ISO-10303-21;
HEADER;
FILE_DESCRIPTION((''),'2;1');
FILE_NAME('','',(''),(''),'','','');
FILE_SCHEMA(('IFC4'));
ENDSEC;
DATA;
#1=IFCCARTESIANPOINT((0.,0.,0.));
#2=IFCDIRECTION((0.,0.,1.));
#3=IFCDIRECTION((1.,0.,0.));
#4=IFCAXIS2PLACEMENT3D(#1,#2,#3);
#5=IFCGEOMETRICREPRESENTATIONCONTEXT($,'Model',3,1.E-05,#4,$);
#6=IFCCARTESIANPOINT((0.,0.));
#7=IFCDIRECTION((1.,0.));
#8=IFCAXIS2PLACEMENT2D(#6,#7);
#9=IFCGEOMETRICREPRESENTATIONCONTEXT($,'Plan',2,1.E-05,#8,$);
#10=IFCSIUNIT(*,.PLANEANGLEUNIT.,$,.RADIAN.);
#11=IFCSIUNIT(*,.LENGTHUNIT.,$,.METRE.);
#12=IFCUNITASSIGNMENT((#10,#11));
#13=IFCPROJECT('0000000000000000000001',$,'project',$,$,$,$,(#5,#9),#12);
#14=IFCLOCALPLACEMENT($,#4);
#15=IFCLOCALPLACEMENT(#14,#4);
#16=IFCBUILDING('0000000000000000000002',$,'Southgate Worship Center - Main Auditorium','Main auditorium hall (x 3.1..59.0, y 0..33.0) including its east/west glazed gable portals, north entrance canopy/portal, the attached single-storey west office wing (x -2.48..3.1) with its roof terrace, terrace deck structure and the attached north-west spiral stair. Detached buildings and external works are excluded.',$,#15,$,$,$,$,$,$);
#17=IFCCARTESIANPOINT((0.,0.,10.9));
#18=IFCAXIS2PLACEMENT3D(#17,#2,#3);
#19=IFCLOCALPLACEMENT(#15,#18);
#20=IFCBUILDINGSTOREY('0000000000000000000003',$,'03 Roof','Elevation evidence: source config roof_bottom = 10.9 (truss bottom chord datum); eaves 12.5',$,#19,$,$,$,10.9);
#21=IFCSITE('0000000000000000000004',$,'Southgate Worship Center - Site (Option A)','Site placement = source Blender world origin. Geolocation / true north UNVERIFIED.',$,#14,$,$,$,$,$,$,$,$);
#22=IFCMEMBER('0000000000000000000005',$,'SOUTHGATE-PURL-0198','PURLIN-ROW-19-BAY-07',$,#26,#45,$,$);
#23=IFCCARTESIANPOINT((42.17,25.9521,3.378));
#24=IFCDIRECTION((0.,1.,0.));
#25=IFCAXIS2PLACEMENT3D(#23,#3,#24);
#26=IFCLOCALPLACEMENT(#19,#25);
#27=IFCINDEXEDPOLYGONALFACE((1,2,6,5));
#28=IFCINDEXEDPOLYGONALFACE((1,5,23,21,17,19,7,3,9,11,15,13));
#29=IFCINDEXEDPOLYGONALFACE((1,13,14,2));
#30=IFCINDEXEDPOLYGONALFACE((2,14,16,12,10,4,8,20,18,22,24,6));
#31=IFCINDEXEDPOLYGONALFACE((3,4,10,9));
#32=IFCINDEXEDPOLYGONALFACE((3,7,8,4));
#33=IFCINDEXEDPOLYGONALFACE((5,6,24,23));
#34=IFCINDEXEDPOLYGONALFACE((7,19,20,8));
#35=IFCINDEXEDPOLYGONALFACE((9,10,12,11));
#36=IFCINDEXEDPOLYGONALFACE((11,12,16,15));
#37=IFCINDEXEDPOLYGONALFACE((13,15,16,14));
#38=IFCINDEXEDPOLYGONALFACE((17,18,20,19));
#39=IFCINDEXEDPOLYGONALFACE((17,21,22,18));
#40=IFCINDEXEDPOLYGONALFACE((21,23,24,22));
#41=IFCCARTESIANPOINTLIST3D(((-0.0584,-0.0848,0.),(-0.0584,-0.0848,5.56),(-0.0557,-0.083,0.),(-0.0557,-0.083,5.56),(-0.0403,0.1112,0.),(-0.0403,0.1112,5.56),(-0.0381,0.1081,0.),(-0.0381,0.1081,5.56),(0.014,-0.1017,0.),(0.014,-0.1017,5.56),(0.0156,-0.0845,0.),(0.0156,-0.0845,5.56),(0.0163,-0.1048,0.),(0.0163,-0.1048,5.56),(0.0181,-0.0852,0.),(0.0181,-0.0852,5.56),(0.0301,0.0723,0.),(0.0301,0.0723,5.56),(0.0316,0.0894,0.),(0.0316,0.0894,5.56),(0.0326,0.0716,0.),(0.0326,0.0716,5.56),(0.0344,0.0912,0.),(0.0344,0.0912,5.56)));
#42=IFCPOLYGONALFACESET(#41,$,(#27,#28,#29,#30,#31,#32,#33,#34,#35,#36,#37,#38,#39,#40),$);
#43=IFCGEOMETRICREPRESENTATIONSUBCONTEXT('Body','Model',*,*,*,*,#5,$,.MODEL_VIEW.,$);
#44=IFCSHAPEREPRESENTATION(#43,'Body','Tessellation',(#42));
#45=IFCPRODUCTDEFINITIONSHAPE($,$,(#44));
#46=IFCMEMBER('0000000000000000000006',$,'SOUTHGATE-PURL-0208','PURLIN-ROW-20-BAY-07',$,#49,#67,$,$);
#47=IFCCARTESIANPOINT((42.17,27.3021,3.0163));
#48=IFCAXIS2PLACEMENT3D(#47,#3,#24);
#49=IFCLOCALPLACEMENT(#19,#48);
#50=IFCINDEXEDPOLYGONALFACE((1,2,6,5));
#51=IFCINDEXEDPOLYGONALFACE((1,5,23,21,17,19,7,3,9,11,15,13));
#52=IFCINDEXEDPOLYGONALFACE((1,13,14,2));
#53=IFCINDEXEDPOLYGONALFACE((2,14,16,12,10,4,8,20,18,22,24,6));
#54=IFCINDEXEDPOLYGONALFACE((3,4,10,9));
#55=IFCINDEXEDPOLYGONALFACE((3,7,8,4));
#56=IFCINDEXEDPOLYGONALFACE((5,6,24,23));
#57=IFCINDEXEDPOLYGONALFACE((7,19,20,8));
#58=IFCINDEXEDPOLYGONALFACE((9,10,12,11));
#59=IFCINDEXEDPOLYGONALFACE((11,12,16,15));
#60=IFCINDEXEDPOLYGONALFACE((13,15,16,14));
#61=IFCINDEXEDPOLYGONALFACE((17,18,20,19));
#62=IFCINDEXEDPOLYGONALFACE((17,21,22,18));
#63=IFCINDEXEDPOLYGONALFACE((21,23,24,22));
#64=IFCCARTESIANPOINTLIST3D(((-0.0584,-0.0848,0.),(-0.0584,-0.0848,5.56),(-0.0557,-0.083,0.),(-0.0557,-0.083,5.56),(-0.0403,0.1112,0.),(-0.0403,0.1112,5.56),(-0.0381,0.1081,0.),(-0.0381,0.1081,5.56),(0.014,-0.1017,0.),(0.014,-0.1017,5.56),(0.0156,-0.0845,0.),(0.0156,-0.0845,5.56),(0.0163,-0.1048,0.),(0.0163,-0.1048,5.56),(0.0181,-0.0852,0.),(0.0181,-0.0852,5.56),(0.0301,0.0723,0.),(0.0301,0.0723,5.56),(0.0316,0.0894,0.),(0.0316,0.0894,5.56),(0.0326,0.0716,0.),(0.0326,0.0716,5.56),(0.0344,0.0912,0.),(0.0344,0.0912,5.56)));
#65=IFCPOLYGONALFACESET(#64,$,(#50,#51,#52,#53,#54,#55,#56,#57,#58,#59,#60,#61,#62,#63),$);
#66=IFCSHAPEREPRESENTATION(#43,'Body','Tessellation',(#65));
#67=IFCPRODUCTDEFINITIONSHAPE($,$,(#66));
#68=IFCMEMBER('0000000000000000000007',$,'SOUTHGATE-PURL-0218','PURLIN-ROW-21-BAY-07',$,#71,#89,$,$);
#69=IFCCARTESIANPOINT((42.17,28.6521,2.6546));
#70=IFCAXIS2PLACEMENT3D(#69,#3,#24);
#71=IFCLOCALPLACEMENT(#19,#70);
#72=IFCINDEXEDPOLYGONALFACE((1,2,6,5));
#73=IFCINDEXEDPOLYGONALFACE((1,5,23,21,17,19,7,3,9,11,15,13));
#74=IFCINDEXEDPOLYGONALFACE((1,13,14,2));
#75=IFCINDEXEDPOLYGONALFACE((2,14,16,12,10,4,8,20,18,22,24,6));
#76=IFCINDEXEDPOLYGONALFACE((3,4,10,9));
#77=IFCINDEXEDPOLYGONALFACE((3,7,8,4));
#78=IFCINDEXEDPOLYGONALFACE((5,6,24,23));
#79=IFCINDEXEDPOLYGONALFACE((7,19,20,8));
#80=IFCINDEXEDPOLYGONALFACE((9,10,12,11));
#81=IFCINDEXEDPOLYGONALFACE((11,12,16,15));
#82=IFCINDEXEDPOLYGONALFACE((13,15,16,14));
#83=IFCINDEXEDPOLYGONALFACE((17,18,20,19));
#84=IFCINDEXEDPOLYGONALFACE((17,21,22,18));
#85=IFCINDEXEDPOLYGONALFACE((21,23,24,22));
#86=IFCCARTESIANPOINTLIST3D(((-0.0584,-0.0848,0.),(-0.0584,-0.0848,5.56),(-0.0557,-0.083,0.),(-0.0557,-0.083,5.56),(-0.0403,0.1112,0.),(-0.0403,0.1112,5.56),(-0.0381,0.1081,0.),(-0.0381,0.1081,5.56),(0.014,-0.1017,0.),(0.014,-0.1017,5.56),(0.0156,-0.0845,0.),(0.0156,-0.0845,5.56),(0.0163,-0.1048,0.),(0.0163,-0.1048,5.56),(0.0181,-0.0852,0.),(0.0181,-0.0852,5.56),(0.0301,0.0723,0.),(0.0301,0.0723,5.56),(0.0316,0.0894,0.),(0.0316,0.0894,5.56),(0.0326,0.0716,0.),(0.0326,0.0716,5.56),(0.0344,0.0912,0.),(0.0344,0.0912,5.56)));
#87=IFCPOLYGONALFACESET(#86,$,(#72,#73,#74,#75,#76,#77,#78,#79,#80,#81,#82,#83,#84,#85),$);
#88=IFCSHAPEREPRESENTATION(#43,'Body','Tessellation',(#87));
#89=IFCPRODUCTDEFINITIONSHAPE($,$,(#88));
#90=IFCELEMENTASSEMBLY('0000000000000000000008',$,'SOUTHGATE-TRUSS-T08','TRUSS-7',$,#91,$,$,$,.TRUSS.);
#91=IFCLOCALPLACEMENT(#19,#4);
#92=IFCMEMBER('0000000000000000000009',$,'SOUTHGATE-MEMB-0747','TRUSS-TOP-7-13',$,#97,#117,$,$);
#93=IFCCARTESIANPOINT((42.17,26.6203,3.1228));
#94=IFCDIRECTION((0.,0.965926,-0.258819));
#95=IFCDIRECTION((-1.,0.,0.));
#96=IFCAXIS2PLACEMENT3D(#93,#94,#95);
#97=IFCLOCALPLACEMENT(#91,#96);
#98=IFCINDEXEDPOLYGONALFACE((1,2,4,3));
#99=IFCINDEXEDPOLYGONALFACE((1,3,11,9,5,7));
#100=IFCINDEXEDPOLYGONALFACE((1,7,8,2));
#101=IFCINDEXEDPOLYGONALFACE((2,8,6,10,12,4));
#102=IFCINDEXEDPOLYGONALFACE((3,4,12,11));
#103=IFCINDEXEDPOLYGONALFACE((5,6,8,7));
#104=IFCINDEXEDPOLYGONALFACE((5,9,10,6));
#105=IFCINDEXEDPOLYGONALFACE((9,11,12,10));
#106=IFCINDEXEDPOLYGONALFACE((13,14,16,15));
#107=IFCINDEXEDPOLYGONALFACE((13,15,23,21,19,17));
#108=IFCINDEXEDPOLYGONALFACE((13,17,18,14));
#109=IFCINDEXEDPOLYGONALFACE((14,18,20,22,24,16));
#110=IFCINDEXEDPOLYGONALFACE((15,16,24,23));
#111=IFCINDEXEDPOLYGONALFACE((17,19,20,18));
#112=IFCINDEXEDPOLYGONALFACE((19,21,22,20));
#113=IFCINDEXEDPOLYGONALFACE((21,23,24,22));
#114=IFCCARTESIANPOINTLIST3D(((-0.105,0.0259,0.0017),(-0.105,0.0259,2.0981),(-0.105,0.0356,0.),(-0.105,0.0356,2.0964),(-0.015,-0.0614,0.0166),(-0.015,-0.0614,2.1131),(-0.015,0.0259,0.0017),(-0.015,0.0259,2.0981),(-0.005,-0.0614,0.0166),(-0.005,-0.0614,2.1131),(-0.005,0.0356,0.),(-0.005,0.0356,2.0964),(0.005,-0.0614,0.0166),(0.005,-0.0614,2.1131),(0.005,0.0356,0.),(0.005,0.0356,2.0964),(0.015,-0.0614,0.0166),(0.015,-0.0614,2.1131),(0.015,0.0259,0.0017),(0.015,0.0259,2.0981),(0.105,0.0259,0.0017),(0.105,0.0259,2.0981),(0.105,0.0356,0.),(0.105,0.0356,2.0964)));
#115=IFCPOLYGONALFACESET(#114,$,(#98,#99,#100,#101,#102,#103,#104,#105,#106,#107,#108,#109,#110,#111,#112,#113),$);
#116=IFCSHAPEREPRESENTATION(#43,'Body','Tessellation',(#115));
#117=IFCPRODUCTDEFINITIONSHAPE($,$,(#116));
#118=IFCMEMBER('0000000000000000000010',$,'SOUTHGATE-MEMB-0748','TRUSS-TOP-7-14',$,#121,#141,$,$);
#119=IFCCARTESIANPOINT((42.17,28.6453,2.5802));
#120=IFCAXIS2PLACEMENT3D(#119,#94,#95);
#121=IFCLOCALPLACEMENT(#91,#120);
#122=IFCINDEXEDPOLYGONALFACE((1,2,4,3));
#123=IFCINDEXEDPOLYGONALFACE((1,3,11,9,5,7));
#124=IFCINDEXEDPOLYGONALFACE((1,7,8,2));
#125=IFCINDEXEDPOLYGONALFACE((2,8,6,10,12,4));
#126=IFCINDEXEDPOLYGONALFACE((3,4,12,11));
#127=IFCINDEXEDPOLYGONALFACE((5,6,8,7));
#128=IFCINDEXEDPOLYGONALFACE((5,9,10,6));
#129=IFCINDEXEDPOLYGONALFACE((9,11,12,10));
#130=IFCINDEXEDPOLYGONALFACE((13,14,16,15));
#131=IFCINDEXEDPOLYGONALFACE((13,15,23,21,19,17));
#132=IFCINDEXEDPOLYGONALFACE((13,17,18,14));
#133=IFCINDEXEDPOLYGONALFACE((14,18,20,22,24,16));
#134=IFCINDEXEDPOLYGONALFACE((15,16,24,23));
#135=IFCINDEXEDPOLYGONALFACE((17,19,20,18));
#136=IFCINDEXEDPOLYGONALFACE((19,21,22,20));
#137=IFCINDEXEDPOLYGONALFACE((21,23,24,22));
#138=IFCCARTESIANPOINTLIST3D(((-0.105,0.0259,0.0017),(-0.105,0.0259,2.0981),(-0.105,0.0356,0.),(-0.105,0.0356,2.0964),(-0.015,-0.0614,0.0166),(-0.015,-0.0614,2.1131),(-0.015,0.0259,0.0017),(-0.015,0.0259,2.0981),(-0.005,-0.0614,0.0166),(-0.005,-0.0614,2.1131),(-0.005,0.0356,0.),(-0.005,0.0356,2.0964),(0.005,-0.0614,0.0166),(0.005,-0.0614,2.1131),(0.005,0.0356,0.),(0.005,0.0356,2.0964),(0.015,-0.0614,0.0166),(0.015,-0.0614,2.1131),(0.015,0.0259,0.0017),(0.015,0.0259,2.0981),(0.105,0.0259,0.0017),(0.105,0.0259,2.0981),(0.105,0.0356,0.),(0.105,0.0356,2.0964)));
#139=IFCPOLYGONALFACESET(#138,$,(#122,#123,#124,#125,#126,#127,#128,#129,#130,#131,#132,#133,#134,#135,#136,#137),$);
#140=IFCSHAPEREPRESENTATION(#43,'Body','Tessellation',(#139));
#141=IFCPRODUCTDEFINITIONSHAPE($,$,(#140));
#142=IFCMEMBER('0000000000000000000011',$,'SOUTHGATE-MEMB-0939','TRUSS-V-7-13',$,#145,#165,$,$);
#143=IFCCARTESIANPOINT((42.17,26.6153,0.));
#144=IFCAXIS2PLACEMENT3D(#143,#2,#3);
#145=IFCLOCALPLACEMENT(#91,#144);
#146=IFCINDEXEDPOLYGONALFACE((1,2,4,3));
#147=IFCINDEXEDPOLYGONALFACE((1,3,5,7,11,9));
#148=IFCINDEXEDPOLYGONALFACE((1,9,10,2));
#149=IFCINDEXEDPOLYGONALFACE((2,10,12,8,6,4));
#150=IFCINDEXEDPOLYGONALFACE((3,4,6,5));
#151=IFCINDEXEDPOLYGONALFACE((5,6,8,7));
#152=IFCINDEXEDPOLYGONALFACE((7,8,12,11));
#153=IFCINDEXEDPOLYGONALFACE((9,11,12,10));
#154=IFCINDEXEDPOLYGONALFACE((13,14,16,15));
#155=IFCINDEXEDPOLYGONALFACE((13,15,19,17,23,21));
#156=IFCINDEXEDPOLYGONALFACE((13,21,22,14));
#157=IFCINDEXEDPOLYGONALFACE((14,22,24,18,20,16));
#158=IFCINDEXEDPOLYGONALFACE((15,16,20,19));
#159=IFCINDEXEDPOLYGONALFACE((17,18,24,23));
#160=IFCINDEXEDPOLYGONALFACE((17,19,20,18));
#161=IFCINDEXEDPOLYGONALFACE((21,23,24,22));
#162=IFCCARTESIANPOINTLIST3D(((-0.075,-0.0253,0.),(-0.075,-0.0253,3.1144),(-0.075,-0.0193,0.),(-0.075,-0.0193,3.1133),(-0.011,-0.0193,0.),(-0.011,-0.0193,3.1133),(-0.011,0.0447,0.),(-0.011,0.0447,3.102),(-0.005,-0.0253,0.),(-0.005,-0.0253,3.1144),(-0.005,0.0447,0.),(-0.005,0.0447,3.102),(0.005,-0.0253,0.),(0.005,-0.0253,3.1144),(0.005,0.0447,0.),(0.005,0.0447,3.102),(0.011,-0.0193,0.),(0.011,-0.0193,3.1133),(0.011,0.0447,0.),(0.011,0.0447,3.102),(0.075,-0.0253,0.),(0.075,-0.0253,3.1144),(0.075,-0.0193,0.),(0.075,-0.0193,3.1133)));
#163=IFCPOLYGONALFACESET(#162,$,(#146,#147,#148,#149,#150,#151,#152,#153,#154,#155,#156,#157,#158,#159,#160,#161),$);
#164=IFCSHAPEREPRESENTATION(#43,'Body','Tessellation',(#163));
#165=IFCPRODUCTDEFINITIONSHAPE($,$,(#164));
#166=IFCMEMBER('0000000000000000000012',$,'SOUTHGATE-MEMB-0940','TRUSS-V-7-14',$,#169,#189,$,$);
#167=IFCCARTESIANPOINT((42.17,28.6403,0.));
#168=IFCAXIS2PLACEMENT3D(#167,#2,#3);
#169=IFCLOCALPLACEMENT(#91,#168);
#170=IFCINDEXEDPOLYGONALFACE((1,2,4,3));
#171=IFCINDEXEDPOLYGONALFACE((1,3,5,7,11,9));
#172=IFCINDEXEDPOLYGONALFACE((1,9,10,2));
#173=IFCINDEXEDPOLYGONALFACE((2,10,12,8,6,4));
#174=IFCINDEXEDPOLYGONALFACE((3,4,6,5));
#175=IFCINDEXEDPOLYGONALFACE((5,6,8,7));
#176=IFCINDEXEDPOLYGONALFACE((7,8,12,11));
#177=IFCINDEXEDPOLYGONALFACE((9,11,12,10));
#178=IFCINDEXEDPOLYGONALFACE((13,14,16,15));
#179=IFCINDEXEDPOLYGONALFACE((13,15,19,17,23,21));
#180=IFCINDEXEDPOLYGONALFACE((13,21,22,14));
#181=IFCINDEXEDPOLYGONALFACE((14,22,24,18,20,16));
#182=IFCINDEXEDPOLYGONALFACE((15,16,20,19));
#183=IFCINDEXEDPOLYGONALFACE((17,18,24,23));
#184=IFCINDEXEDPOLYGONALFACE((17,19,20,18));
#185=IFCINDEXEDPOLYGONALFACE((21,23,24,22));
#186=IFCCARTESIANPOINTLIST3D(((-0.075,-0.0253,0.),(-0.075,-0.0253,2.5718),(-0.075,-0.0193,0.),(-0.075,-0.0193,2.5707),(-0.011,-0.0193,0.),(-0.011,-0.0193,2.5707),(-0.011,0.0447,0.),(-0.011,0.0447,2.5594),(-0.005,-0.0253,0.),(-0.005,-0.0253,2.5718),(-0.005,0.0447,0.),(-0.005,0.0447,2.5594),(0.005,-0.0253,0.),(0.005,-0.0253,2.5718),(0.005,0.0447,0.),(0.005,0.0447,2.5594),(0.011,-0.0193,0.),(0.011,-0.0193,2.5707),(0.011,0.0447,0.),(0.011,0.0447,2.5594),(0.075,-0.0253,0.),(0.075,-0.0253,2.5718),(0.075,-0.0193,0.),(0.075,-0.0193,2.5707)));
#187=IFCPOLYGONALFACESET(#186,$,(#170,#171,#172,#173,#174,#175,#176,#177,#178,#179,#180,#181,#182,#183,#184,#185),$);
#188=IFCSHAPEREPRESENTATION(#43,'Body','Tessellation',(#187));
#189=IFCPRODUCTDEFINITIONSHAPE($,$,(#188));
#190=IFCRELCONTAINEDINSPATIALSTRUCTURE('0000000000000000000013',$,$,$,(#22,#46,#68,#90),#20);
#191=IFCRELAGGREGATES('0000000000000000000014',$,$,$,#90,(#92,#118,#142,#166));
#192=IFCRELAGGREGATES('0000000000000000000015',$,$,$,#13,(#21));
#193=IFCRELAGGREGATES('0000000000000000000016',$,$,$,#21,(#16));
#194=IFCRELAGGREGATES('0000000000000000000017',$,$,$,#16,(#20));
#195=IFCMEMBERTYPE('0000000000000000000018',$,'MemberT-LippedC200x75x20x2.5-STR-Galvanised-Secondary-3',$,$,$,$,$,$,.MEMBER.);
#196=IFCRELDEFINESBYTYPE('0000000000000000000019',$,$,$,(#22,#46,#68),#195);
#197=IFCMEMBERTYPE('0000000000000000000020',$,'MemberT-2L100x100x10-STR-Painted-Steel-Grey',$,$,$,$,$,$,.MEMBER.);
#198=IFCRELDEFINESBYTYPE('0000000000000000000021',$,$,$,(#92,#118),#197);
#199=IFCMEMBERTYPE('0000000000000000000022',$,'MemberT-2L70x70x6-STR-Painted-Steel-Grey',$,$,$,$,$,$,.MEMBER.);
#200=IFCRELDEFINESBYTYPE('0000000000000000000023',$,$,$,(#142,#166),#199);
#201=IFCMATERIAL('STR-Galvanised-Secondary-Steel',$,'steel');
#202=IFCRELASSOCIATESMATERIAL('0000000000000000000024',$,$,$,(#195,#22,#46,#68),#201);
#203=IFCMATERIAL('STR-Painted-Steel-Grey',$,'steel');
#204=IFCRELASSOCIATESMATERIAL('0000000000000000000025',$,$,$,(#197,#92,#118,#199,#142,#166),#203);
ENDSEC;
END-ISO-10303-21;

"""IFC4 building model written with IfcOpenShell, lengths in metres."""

from ifc_helpers import new_model, si_unit, frame, origin_with_axes, origin_2d_with_axis, place, context, subcontext, project, spatial, indexed_curve, outline, composite_profile, extrude, clip, halfspace, material, material_profile, profile_set, profile_usage, type_object, element, aggregate, save


model = new_model("IFC4")

# Units and contexts
model_context = context("Model", 3, precision=1e-05, world=origin_with_axes())
plan_context = context("Plan", 2, precision=1e-05, world=origin_2d_with_axis())
body_context = subcontext(model_context, "Body", "Model", "MODEL_VIEW")
ifc_project = project(units=[si_unit("PLANEANGLEUNIT", "RADIAN"), si_unit("LENGTHUNIT", "METRE")], contexts=[model_context, plan_context])

# Site, building, storey
site_placement = place(None, origin_with_axes())
site = spatial("IfcSite", under=ifc_project, at=site_placement, Name="Southgate Worship Center - Site (Option A)", Description="Site placement = source Blender world origin. Geolocation / true north UNVERIFIED.")
building_placement = place(site_placement, origin_with_axes())
building = spatial("IfcBuilding", under=site, at=building_placement, Name="Southgate Worship Center - Main Auditorium", Description="Main auditorium hall (x 3.1..59.0, y 0..33.0) including its east/west glazed gable portals, north entrance canopy/portal, the attached single-storey west office wing (x -2.48..3.1) with its roof terrace, terrace deck structure and the attached north-west spiral stair. Detached buildings and external works are excluded.")
storey_placement = place(building_placement, frame((0.0, 0.0, 10.9), z_axis=(0.0, 0.0, 1.0), x_axis=(1.0, 0.0, 0.0)))
storey = spatial("IfcBuildingStorey", under=building, at=storey_placement, Name="03 Roof", Description="Elevation evidence: source config roof_bottom = 10.9 (truss bottom chord datum); eaves 12.5", Elevation=10.9)

# Members
ifc_material_1 = material(Name="STR-Galvanised-Secondary-Steel", Category="steel")
ifc_material_profile_1 = material_profile(ifc_material_1, outline(indexed_curve([(0.0326, 0.0716), (0.0344, 0.0912), (-0.0403, 0.1112), (-0.0584, -0.0848), (0.0163, -0.1048), (0.0181, -0.0852), (0.0156, -0.0845), (0.014, -0.1017), (-0.0557, -0.083), (-0.0381, 0.1081), (0.0316, 0.0894), (0.0301, 0.0723), (0.0326, 0.0716)], self_intersect=False)))
ifc_profile_set_1 = profile_set([ifc_material_profile_1], Name="MemberT-LippedC200x75x20x2.5-STR-Galvanised-Secondary-3")
ifc_profile_usage_1 = profile_usage(ifc_profile_set_1)
member_type_1 = type_object("IfcMemberType", Name="MemberT-LippedC200x75x20x2.5-STR-Galvanised-Secondary-3", PredefinedType="MEMBER", material=ifc_profile_set_1)
for number, where, z_axis, x_axis, name, description in (
    (1, (42.17, 25.9521, 3.378), (1.0, 0.0, 0.0), (0.0, 1.0, 0.0), "SOUTHGATE-PURL-0198", "PURLIN-ROW-19-BAY-07"),
    (2, (42.17, 27.3021, 3.0163), (1.0, 0.0, 0.0), (0.0, 1.0, 0.0), "SOUTHGATE-PURL-0208", "PURLIN-ROW-20-BAY-07"),
    (3, (42.17, 28.6521, 2.6546), (1.0, 0.0, 0.0), (0.0, 1.0, 0.0), "SOUTHGATE-PURL-0218", "PURLIN-ROW-21-BAY-07"),
):
    element("IfcMember", number, at=place(storey_placement, frame(where, z_axis=z_axis, x_axis=x_axis)), inside=storey, type_object=member_type_1, material=ifc_profile_usage_1, Name=name, Description=description, context=body_context, shape_type="SweptSolid", body=[
        extrude(outline(indexed_curve([(0.0326, 0.0716), (0.0344, 0.0912), (-0.0403, 0.1112), (-0.0584, -0.0848), (0.0163, -0.1048), (0.0181, -0.0852), (0.0156, -0.0845), (0.014, -0.1017), (-0.0557, -0.083), (-0.0381, 0.1081), (0.0316, 0.0894), (0.0301, 0.0723), (0.0326, 0.0716)], self_intersect=False)), origin_with_axes(), (0.0, 0.0, 1.0), 5.56),
    ])

# Element assembly, members
assembly_1_placement = place(storey_placement, origin_with_axes())
assembly_1 = element("IfcElementAssembly", 4, at=assembly_1_placement, inside=storey, Name="SOUTHGATE-TRUSS-T08", Description="TRUSS-7", PredefinedType="TRUSS")
ifc_material_2 = material(Name="STR-Painted-Steel-Grey", Category="steel")
ifc_material_profile_2 = material_profile(ifc_material_2, composite_profile([outline(indexed_curve([(0.005, 0.0356), (0.005, -0.0614), (0.015, -0.0614), (0.015, 0.0259), (0.105, 0.0259), (0.105, 0.0356), (0.005, 0.0356)], self_intersect=False)), outline(indexed_curve([(-0.105, 0.0356), (-0.105, 0.0259), (-0.015, 0.0259), (-0.015, -0.0614), (-0.005, -0.0614), (-0.005, 0.0356), (-0.105, 0.0356)], self_intersect=False))]))
ifc_profile_set_2 = profile_set([ifc_material_profile_2], Name="MemberT-2L100x100x10-STR-Painted-Steel-Grey")
ifc_profile_usage_2 = profile_usage(ifc_profile_set_2)
member_type_2 = type_object("IfcMemberType", Name="MemberT-2L100x100x10-STR-Painted-Steel-Grey", PredefinedType="MEMBER", material=ifc_profile_set_2)
member_1_placement = place(assembly_1_placement, frame((42.17, 26.6203, 3.1228), z_axis=(0.0, 0.965926, -0.258819), x_axis=(-1.0, 0.0, 0.0)))
member_1 = element("IfcMember", 5, at=member_1_placement, type_object=member_type_2, material=ifc_profile_usage_2, Name="SOUTHGATE-MEMB-0747", Description="TRUSS-TOP-7-13", context=body_context, shape_type="Clipping", body=[
    clip(clip(extrude(composite_profile([outline(indexed_curve([(0.005, 0.0356), (0.005, -0.0614), (0.015, -0.0614), (0.015, 0.0259), (0.105, 0.0259), (0.105, 0.0356), (0.005, 0.0356)], self_intersect=False)), outline(indexed_curve([(-0.105, 0.0356), (-0.105, 0.0259), (-0.015, 0.0259), (-0.015, -0.0614), (-0.005, -0.0614), (-0.005, 0.0356), (-0.105, 0.0356)], self_intersect=False))]), origin_with_axes(), (0.0, 0.0, 1.0), 2.1131), halfspace(frame((0.0417, 0.0, 0.0061), z_axis=(0.000001, -0.16886, -0.98564), x_axis=(1.0, 0.000007, 0.0)), False)), halfspace(frame((0.0417, 0.0, 2.1025), z_axis=(-0.000001, 0.16886, 0.98564), x_axis=(-1.0, -0.000007, 0.0)), False)),
])
member_2_placement = place(assembly_1_placement, frame((42.17, 28.6453, 2.5802), z_axis=(0.0, 0.965926, -0.258819), x_axis=(-1.0, 0.0, 0.0)))
member_2 = element("IfcMember", 6, at=member_2_placement, type_object=member_type_2, material=ifc_profile_usage_2, Name="SOUTHGATE-MEMB-0748", Description="TRUSS-TOP-7-14", context=body_context, shape_type="Clipping", body=[
    clip(clip(extrude(composite_profile([outline(indexed_curve([(0.005, 0.0356), (0.005, -0.0614), (0.015, -0.0614), (0.015, 0.0259), (0.105, 0.0259), (0.105, 0.0356), (0.005, 0.0356)], self_intersect=False)), outline(indexed_curve([(-0.105, 0.0356), (-0.105, 0.0259), (-0.015, 0.0259), (-0.015, -0.0614), (-0.005, -0.0614), (-0.005, 0.0356), (-0.105, 0.0356)], self_intersect=False))]), origin_with_axes(), (0.0, 0.0, 1.0), 2.1131), halfspace(frame((0.0417, 0.0, 0.0061), z_axis=(0.000001, -0.16886, -0.98564), x_axis=(1.0, 0.000007, 0.0)), False)), halfspace(frame((0.0417, 0.0, 2.1025), z_axis=(-0.000001, 0.16886, 0.98564), x_axis=(-1.0, -0.000007, 0.0)), False)),
])
ifc_material_profile_3 = material_profile(ifc_material_2, composite_profile([outline(indexed_curve([(-0.075, -0.0253), (-0.005, -0.0253), (-0.005, 0.0447), (-0.011, 0.0447), (-0.011, -0.0193), (-0.075, -0.0193), (-0.075, -0.0253)], self_intersect=False)), outline(indexed_curve([(0.011, 0.0447), (0.005, 0.0447), (0.005, -0.0253), (0.075, -0.0253), (0.075, -0.0193), (0.011, -0.0193), (0.011, 0.0447)], self_intersect=False))]))
ifc_profile_set_3 = profile_set([ifc_material_profile_3], Name="MemberT-2L70x70x6-STR-Painted-Steel-Grey")
ifc_profile_usage_3 = profile_usage(ifc_profile_set_3)
member_type_3 = type_object("IfcMemberType", Name="MemberT-2L70x70x6-STR-Painted-Steel-Grey", PredefinedType="MEMBER", material=ifc_profile_set_3)
member_3_placement = place(assembly_1_placement, frame((42.17, 26.6153, 0.0), z_axis=(0.0, 0.0, 1.0), x_axis=(1.0, 0.0, 0.0)))
member_3 = element("IfcMember", 7, at=member_3_placement, type_object=member_type_3, material=ifc_profile_usage_3, Name="SOUTHGATE-MEMB-0939", Description="TRUSS-V-7-13", context=body_context, shape_type="Clipping", body=[
    clip(extrude(composite_profile([outline(indexed_curve([(-0.075, -0.0253), (-0.005, -0.0253), (-0.005, 0.0447), (-0.011, 0.0447), (-0.011, -0.0193), (-0.075, -0.0193), (-0.075, -0.0253)], self_intersect=False)), outline(indexed_curve([(0.011, 0.0447), (0.005, 0.0447), (0.005, -0.0253), (0.075, -0.0253), (0.075, -0.0193), (0.011, -0.0193), (0.011, 0.0447)], self_intersect=False))]), origin_with_axes(), (0.0, 0.0, 1.0), 3.1144), halfspace(frame((-0.0303, 0.0, 3.1099), z_axis=(0.0, 0.174319, 0.984689), x_axis=(-1.0, -0.000001, 0.0)), False)),
])
member_4_placement = place(assembly_1_placement, frame((42.17, 28.6403, 0.0), z_axis=(0.0, 0.0, 1.0), x_axis=(1.0, 0.0, 0.0)))
member_4 = element("IfcMember", 8, at=member_4_placement, type_object=member_type_3, material=ifc_profile_usage_3, Name="SOUTHGATE-MEMB-0940", Description="TRUSS-V-7-14", context=body_context, shape_type="Clipping", body=[
    clip(extrude(composite_profile([outline(indexed_curve([(-0.075, -0.0253), (-0.005, -0.0253), (-0.005, 0.0447), (-0.011, 0.0447), (-0.011, -0.0193), (-0.075, -0.0193), (-0.075, -0.0253)], self_intersect=False)), outline(indexed_curve([(0.011, 0.0447), (0.005, 0.0447), (0.005, -0.0253), (0.075, -0.0253), (0.075, -0.0193), (0.011, -0.0193), (0.011, 0.0447)], self_intersect=False))]), origin_with_axes(), (0.0, 0.0, 1.0), 2.5718), halfspace(frame((-0.0303, 0.0, 2.5673), z_axis=(0.000001, 0.174324, 0.984688), x_axis=(-1.0, 0.000006, 0.0)), False)),
])

aggregate(assembly_1, [member_1, member_2, member_3, member_4])

save(model, "model.ifc")
